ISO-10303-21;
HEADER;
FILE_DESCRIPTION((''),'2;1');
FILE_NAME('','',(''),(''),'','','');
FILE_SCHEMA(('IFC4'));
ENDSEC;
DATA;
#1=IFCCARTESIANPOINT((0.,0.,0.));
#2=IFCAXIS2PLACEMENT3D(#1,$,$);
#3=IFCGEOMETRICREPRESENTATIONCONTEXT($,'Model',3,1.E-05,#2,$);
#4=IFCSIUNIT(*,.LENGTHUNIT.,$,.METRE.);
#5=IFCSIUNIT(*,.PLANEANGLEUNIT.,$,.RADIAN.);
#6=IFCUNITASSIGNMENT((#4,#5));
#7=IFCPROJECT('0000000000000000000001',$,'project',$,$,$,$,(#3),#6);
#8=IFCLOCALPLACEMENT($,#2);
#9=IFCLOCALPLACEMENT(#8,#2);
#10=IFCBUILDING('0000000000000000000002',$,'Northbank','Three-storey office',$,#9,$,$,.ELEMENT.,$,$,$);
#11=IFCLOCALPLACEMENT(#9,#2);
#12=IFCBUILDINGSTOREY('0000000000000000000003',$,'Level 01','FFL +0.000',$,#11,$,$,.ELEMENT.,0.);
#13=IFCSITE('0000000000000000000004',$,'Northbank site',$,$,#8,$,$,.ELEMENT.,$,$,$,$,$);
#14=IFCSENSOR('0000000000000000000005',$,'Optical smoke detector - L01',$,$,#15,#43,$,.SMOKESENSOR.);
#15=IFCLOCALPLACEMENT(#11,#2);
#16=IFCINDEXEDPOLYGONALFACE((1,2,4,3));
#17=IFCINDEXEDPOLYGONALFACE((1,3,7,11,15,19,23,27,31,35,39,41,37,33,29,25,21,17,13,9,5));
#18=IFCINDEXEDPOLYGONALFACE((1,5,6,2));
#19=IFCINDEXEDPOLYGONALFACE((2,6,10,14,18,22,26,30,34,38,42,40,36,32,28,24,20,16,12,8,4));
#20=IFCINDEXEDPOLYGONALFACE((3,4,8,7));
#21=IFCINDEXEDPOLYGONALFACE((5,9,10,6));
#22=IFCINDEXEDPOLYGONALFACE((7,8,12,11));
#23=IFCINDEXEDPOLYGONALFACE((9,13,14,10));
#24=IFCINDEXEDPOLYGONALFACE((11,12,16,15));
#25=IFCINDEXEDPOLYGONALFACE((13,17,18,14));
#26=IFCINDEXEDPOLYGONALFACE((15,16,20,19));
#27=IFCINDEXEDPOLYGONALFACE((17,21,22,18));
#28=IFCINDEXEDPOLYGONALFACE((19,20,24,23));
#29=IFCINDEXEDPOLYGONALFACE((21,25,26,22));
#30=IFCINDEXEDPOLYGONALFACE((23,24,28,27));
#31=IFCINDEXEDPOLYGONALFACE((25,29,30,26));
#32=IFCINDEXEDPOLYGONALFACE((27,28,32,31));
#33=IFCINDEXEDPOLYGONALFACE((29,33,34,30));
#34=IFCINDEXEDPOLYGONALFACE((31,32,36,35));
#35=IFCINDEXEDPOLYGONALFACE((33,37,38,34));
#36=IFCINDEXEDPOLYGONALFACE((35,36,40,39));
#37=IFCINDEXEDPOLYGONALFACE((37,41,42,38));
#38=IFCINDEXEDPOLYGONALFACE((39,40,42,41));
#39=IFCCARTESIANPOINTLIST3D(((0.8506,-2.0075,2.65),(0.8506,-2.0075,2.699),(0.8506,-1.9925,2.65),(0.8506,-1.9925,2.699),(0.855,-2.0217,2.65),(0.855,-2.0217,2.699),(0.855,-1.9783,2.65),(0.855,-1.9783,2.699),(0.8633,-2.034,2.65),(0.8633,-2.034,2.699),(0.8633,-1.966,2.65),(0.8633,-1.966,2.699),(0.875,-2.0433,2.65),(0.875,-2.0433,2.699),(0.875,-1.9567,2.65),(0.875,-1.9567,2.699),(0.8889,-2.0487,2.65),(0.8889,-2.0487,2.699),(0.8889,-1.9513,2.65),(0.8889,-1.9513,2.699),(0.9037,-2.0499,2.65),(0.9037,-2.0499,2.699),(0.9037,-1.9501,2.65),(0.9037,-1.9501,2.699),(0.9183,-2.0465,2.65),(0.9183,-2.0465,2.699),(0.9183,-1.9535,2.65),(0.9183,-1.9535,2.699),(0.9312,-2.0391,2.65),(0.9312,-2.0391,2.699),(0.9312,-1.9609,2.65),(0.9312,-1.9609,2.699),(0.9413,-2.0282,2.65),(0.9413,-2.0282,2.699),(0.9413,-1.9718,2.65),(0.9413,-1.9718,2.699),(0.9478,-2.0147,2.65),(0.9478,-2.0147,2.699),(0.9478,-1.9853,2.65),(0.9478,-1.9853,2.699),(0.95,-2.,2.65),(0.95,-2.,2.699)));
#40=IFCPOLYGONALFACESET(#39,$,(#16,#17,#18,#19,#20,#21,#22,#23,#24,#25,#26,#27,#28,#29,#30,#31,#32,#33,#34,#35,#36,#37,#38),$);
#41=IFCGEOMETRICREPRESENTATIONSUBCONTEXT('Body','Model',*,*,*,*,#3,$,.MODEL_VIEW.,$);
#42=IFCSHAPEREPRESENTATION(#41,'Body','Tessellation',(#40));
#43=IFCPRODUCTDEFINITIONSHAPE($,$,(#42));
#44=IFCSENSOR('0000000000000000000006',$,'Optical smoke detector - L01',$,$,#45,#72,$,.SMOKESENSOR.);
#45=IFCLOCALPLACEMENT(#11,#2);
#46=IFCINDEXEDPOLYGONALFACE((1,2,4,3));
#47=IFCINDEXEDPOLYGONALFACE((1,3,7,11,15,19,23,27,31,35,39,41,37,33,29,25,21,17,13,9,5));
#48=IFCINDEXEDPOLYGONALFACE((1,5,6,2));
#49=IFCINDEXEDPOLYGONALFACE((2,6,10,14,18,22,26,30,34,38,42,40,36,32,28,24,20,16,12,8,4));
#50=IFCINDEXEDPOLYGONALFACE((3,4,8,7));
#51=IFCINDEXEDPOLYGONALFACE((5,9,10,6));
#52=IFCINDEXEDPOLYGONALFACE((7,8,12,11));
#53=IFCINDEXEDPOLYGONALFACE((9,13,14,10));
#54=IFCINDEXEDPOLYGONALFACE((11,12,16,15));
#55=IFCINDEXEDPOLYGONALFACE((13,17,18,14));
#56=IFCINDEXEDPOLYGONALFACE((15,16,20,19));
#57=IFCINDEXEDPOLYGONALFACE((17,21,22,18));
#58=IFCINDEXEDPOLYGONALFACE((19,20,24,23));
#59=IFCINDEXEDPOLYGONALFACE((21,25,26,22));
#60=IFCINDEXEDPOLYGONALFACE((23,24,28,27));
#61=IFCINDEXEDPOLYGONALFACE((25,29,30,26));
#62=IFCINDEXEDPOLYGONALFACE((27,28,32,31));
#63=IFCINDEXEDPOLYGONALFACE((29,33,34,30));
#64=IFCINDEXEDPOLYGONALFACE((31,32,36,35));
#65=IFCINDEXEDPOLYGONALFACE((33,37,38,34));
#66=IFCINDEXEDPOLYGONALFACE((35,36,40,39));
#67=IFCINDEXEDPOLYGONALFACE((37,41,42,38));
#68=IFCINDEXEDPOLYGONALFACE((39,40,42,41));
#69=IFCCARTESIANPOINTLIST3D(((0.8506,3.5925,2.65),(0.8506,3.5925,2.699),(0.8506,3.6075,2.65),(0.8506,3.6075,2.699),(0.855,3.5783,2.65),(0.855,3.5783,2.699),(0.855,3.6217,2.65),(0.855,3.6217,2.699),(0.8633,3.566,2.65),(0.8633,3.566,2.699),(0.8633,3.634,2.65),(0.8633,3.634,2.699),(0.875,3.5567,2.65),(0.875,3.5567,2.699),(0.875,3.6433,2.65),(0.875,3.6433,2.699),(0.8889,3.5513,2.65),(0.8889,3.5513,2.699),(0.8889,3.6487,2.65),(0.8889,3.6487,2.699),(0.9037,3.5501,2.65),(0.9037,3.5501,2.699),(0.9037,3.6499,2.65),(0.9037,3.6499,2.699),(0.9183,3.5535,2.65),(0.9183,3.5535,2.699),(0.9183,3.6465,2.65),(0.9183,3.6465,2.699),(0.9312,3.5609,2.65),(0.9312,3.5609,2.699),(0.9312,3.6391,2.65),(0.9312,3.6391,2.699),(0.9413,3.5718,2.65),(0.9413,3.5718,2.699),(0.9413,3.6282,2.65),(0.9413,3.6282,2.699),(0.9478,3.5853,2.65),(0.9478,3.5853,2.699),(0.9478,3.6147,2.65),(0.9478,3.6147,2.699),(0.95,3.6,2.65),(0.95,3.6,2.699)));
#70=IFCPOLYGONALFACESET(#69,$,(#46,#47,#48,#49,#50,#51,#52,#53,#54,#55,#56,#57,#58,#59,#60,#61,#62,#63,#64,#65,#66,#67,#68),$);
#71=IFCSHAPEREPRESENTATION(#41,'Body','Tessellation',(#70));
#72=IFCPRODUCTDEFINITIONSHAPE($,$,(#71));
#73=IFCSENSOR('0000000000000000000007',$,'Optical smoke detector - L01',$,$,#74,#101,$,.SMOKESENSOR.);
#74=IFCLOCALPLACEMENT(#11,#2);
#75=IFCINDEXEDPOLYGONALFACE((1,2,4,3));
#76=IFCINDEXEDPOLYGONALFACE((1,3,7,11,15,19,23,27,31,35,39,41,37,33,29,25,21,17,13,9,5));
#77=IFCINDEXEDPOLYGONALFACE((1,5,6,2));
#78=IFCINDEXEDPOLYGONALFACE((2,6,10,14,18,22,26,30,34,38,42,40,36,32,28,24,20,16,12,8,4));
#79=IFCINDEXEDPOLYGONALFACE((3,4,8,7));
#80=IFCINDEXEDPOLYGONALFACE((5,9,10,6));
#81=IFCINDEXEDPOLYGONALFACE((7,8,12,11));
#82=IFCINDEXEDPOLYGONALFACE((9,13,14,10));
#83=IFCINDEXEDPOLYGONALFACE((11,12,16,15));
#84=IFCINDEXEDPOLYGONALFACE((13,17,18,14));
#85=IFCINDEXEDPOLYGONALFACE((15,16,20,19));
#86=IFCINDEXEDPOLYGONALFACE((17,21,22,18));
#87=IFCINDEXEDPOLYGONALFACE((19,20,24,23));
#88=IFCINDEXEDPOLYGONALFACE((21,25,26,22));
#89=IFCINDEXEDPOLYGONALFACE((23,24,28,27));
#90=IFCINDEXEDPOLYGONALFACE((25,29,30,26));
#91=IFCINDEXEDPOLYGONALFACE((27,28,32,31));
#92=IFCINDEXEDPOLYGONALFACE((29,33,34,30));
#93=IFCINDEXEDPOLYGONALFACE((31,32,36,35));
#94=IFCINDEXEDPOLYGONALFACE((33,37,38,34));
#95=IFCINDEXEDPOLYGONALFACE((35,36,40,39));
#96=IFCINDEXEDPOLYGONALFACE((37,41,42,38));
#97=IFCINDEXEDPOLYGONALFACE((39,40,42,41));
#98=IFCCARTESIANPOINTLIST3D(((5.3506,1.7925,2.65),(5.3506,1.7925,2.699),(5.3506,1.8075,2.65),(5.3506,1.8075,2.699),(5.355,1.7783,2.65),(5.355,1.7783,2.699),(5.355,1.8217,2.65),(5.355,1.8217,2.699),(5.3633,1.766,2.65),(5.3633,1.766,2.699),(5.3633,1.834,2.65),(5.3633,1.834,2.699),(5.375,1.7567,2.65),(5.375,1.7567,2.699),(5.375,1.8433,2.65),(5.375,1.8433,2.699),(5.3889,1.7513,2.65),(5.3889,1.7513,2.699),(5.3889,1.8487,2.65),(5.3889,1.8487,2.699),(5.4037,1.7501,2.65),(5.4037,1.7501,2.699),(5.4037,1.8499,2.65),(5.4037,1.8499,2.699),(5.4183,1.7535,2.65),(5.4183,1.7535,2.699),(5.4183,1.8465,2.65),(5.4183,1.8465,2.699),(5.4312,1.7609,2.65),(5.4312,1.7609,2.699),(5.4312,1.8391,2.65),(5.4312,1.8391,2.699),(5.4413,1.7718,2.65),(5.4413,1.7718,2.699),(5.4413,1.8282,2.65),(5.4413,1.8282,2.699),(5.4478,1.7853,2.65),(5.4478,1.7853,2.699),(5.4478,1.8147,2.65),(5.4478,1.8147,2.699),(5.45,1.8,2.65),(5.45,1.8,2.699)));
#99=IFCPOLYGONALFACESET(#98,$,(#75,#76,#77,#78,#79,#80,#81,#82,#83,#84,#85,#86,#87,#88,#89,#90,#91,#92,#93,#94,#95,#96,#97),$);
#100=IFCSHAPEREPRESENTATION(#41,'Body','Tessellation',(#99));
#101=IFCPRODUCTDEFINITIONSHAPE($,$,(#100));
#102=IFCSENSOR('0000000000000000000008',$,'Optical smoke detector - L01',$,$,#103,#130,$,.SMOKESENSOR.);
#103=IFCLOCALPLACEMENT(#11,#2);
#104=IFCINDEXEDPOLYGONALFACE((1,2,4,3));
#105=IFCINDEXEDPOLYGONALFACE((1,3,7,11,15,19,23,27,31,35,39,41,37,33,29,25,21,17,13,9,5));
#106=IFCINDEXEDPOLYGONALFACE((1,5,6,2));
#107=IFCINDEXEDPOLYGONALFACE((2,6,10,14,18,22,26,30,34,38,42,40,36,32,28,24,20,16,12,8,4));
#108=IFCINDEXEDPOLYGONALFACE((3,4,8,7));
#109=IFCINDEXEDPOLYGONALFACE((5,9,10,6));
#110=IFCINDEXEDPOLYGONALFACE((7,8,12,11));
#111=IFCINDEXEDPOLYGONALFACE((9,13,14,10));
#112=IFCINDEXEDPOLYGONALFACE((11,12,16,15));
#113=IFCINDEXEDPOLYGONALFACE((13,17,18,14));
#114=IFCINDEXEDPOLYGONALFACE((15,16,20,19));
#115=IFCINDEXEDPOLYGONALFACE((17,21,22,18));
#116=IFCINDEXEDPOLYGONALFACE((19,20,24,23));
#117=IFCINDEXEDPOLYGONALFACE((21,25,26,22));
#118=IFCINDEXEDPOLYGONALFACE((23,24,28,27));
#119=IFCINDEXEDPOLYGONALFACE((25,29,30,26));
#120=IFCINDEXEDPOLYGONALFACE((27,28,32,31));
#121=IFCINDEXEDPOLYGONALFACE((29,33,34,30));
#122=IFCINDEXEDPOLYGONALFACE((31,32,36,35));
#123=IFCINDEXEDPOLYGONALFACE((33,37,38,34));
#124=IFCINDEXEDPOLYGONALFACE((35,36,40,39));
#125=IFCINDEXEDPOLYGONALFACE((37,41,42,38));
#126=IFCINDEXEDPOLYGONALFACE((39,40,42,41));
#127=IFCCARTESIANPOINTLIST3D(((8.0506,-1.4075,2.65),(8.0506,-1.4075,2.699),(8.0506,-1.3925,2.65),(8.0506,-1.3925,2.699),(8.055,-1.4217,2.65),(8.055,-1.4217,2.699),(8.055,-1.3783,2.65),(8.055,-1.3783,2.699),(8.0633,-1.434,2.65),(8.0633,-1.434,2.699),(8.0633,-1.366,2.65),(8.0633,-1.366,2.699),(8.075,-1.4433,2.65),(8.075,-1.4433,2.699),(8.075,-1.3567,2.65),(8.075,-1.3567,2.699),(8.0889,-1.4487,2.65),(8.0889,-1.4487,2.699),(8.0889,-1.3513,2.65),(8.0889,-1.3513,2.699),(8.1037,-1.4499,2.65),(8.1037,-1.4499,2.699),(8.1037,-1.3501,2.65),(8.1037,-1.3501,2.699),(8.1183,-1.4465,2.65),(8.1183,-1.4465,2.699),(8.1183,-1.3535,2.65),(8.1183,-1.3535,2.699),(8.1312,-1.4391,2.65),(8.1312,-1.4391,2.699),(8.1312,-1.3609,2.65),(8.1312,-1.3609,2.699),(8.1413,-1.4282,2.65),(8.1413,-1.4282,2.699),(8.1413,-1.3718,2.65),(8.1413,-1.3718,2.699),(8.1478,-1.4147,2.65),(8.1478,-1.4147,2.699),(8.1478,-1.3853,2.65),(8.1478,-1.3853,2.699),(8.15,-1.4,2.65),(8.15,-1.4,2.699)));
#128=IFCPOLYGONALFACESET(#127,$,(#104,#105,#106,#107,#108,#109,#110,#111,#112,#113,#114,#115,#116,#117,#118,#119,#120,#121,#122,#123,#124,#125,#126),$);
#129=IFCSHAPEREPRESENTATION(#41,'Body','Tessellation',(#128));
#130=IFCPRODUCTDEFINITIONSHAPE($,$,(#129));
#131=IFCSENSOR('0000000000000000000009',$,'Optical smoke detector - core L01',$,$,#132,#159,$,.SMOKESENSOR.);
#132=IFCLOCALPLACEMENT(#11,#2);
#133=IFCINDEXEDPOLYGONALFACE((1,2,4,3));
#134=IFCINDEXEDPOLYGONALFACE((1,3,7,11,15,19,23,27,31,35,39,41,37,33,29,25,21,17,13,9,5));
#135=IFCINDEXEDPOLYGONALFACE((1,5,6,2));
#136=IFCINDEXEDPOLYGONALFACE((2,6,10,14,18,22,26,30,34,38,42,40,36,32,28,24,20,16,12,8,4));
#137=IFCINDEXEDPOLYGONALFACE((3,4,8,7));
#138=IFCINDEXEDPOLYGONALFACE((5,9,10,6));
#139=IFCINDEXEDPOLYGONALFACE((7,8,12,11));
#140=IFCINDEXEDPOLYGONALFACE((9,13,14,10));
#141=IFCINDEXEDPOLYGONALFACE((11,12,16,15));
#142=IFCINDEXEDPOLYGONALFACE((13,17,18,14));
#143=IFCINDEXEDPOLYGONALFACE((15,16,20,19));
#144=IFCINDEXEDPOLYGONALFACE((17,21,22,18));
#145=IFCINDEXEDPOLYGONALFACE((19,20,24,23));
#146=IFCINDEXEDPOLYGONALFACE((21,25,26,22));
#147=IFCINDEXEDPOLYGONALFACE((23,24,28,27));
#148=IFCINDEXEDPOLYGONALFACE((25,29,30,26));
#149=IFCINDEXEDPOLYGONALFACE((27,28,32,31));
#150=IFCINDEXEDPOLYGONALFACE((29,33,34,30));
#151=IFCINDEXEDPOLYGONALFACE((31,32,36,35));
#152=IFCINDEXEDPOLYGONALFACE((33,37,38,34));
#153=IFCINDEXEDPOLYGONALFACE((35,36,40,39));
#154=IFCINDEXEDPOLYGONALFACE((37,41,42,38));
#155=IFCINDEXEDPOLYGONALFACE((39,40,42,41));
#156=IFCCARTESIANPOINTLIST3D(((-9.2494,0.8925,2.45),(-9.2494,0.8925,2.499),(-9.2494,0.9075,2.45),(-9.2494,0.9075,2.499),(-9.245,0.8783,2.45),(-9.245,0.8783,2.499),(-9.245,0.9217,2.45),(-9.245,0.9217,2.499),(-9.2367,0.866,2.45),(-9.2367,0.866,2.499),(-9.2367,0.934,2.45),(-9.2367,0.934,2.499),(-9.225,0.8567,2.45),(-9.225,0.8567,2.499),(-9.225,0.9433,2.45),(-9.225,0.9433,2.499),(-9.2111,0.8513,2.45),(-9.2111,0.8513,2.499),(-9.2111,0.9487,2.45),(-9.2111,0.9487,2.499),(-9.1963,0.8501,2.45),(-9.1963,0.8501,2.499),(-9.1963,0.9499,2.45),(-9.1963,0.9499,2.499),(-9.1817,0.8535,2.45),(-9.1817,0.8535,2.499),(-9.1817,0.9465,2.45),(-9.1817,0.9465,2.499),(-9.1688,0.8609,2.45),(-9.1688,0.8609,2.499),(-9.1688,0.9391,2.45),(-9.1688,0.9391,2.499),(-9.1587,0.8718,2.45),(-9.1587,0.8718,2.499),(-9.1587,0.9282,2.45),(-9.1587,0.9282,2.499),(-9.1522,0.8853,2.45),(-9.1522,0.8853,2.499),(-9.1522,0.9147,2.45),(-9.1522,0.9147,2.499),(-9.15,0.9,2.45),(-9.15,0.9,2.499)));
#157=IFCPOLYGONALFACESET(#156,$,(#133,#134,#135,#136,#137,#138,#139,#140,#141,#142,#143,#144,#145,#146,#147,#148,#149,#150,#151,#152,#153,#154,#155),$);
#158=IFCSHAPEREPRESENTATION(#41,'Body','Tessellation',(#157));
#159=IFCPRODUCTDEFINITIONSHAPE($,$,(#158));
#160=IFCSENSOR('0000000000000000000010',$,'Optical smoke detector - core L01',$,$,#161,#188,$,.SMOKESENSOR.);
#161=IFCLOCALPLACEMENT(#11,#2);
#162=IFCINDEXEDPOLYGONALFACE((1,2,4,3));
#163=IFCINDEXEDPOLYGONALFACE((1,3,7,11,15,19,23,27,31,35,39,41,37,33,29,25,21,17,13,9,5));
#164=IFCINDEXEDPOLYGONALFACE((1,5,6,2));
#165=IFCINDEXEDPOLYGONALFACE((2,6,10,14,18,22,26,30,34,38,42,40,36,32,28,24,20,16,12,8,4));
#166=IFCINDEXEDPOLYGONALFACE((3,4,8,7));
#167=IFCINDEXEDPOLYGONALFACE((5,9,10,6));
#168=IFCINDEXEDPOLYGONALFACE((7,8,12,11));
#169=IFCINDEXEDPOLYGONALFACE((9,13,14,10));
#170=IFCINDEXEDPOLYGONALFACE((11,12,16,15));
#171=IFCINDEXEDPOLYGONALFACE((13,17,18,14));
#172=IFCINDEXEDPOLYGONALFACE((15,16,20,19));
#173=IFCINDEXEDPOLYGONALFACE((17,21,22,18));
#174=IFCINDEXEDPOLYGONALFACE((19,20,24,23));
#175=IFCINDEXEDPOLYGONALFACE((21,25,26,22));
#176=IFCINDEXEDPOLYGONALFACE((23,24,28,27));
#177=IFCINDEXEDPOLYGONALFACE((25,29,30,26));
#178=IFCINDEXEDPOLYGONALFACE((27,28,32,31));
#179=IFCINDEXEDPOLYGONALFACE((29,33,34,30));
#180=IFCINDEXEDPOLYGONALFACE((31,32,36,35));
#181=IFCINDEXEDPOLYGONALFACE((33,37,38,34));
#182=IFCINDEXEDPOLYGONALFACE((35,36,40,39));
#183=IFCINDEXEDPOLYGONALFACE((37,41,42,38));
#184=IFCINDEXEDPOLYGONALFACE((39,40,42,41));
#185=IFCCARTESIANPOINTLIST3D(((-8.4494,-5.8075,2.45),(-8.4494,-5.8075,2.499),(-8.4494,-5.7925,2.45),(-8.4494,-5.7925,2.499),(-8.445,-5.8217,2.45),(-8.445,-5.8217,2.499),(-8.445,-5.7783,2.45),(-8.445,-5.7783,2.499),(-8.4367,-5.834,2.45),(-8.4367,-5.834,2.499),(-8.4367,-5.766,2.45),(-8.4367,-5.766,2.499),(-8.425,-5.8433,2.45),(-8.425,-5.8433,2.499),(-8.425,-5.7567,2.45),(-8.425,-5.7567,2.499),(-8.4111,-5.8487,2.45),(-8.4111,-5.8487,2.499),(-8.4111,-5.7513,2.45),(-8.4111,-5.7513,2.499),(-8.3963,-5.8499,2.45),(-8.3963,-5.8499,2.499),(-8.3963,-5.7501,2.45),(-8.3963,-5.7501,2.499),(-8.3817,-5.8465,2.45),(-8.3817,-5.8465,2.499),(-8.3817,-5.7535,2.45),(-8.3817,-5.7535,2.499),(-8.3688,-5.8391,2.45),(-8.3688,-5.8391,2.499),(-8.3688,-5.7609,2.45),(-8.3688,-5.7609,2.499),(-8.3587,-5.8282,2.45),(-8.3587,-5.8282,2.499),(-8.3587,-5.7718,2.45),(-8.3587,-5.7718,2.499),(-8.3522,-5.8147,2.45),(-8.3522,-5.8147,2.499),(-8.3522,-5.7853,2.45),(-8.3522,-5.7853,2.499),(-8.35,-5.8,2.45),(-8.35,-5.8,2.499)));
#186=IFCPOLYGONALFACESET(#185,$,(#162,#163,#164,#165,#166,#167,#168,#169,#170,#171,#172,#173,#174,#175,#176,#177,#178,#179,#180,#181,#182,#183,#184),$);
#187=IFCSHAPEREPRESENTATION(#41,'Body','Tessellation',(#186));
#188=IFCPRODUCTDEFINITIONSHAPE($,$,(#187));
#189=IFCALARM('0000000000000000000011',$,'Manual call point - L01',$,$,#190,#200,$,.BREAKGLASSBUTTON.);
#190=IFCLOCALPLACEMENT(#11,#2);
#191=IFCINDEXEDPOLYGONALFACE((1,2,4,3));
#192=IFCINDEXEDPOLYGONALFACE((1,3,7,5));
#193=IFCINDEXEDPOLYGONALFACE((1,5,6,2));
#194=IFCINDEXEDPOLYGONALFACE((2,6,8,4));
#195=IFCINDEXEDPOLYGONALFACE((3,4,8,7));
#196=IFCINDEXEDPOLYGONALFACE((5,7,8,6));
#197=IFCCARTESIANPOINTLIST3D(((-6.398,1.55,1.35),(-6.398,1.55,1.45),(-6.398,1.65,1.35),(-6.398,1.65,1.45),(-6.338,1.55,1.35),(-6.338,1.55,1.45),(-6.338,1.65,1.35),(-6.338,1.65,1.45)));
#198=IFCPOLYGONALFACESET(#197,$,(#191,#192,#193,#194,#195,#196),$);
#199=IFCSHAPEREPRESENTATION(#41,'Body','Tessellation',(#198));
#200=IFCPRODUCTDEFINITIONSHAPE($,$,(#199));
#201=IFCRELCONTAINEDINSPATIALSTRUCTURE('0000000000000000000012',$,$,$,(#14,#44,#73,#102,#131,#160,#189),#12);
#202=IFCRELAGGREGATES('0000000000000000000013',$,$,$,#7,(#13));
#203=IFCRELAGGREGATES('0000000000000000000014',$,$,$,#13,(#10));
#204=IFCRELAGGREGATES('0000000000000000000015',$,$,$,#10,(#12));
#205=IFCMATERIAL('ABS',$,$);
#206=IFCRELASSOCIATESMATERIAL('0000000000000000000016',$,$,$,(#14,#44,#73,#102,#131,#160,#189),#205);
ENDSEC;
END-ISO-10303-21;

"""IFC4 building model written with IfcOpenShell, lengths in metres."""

from ifc_helpers import new_model, si_unit, frame, origin, place, context, subcontext, project, spatial, rectangle, circle, extrude, material, element, save


model = new_model("IFC4")

# Units and contexts
model_context = context("Model", 3, precision=1e-05, world=origin())
body_context = subcontext(model_context, "Body", "Model", "MODEL_VIEW")
ifc_project = project(units=[si_unit("LENGTHUNIT", "METRE"), si_unit("PLANEANGLEUNIT", "RADIAN")], contexts=[model_context])

# Site, building, storey
site_placement = place(None, origin())
site = spatial("IfcSite", under=ifc_project, at=site_placement, Name="Northbank site", CompositionType="ELEMENT")
building_placement = place(site_placement, origin())
building = spatial("IfcBuilding", under=site, at=building_placement, Name="Northbank", Description="Three-storey office", CompositionType="ELEMENT")
storey_placement = place(building_placement, origin())
storey = spatial("IfcBuildingStorey", under=building, at=storey_placement, Name="Level 01", Description="FFL +0.000", CompositionType="ELEMENT", Elevation=0.0)

# Sensors
ifc_material_1 = material(Name="ABS")
sensor_1_placement = place(storey_placement, origin())
element("IfcSensor", 1, at=sensor_1_placement, inside=storey, material=ifc_material_1, Name="Optical smoke detector - L01", PredefinedType="SMOKESENSOR", context=body_context, shape_type="SweptSolid", body=[
    extrude(circle(Radius=0.05), frame((0.9, -2.0, 2.65), z_axis=(0.0, 0.0, 1.0), x_axis=(1.0, 0.0, 0.0)), (0.0, 0.0, 1.0), 0.049),
])
sensor_2_placement = place(storey_placement, origin())
element("IfcSensor", 2, at=sensor_2_placement, inside=storey, material=ifc_material_1, Name="Optical smoke detector - L01", PredefinedType="SMOKESENSOR", context=body_context, shape_type="SweptSolid", body=[
    extrude(circle(Radius=0.05), frame((0.9, 3.6, 2.65), z_axis=(0.0, 0.0, 1.0), x_axis=(1.0, 0.0, 0.0)), (0.0, 0.0, 1.0), 0.049),
])
sensor_3_placement = place(storey_placement, origin())
element("IfcSensor", 3, at=sensor_3_placement, inside=storey, material=ifc_material_1, Name="Optical smoke detector - L01", PredefinedType="SMOKESENSOR", context=body_context, shape_type="SweptSolid", body=[
    extrude(circle(Radius=0.05), frame((5.4, 1.8, 2.65), z_axis=(0.0, 0.0, 1.0), x_axis=(1.0, 0.0, 0.0)), (0.0, 0.0, 1.0), 0.049),
])
sensor_4_placement = place(storey_placement, origin())
element("IfcSensor", 4, at=sensor_4_placement, inside=storey, material=ifc_material_1, Name="Optical smoke detector - L01", PredefinedType="SMOKESENSOR", context=body_context, shape_type="SweptSolid", body=[
    extrude(circle(Radius=0.05), frame((8.1, -1.4, 2.65), z_axis=(0.0, 0.0, 1.0), x_axis=(1.0, 0.0, 0.0)), (0.0, 0.0, 1.0), 0.049),
])
sensor_5_placement = place(storey_placement, origin())
element("IfcSensor", 5, at=sensor_5_placement, inside=storey, material=ifc_material_1, Name="Optical smoke detector - core L01", PredefinedType="SMOKESENSOR", context=body_context, shape_type="SweptSolid", body=[
    extrude(circle(Radius=0.05), frame((-9.2, 0.9, 2.45), z_axis=(0.0, 0.0, 1.0), x_axis=(1.0, 0.0, 0.0)), (0.0, 0.0, 1.0), 0.049),
])
sensor_6_placement = place(storey_placement, origin())
element("IfcSensor", 6, at=sensor_6_placement, inside=storey, material=ifc_material_1, Name="Optical smoke detector - core L01", PredefinedType="SMOKESENSOR", context=body_context, shape_type="SweptSolid", body=[
    extrude(circle(Radius=0.05), frame((-8.4, -5.8, 2.45), z_axis=(0.0, 0.0, 1.0), x_axis=(1.0, 0.0, 0.0)), (0.0, 0.0, 1.0), 0.049),
])

# Alarm
alarm_1_placement = place(storey_placement, origin())
element("IfcAlarm", 7, at=alarm_1_placement, inside=storey, material=ifc_material_1, Name="Manual call point - L01", PredefinedType="BREAKGLASSBUTTON", context=body_context, shape_type="SweptSolid", body=[
    extrude(rectangle(XDim=0.06, YDim=0.1), frame((-6.368, 1.6, 1.35)), (0.0, 0.0, 1.0), 0.1),
])

save(model, "model.ifc")
